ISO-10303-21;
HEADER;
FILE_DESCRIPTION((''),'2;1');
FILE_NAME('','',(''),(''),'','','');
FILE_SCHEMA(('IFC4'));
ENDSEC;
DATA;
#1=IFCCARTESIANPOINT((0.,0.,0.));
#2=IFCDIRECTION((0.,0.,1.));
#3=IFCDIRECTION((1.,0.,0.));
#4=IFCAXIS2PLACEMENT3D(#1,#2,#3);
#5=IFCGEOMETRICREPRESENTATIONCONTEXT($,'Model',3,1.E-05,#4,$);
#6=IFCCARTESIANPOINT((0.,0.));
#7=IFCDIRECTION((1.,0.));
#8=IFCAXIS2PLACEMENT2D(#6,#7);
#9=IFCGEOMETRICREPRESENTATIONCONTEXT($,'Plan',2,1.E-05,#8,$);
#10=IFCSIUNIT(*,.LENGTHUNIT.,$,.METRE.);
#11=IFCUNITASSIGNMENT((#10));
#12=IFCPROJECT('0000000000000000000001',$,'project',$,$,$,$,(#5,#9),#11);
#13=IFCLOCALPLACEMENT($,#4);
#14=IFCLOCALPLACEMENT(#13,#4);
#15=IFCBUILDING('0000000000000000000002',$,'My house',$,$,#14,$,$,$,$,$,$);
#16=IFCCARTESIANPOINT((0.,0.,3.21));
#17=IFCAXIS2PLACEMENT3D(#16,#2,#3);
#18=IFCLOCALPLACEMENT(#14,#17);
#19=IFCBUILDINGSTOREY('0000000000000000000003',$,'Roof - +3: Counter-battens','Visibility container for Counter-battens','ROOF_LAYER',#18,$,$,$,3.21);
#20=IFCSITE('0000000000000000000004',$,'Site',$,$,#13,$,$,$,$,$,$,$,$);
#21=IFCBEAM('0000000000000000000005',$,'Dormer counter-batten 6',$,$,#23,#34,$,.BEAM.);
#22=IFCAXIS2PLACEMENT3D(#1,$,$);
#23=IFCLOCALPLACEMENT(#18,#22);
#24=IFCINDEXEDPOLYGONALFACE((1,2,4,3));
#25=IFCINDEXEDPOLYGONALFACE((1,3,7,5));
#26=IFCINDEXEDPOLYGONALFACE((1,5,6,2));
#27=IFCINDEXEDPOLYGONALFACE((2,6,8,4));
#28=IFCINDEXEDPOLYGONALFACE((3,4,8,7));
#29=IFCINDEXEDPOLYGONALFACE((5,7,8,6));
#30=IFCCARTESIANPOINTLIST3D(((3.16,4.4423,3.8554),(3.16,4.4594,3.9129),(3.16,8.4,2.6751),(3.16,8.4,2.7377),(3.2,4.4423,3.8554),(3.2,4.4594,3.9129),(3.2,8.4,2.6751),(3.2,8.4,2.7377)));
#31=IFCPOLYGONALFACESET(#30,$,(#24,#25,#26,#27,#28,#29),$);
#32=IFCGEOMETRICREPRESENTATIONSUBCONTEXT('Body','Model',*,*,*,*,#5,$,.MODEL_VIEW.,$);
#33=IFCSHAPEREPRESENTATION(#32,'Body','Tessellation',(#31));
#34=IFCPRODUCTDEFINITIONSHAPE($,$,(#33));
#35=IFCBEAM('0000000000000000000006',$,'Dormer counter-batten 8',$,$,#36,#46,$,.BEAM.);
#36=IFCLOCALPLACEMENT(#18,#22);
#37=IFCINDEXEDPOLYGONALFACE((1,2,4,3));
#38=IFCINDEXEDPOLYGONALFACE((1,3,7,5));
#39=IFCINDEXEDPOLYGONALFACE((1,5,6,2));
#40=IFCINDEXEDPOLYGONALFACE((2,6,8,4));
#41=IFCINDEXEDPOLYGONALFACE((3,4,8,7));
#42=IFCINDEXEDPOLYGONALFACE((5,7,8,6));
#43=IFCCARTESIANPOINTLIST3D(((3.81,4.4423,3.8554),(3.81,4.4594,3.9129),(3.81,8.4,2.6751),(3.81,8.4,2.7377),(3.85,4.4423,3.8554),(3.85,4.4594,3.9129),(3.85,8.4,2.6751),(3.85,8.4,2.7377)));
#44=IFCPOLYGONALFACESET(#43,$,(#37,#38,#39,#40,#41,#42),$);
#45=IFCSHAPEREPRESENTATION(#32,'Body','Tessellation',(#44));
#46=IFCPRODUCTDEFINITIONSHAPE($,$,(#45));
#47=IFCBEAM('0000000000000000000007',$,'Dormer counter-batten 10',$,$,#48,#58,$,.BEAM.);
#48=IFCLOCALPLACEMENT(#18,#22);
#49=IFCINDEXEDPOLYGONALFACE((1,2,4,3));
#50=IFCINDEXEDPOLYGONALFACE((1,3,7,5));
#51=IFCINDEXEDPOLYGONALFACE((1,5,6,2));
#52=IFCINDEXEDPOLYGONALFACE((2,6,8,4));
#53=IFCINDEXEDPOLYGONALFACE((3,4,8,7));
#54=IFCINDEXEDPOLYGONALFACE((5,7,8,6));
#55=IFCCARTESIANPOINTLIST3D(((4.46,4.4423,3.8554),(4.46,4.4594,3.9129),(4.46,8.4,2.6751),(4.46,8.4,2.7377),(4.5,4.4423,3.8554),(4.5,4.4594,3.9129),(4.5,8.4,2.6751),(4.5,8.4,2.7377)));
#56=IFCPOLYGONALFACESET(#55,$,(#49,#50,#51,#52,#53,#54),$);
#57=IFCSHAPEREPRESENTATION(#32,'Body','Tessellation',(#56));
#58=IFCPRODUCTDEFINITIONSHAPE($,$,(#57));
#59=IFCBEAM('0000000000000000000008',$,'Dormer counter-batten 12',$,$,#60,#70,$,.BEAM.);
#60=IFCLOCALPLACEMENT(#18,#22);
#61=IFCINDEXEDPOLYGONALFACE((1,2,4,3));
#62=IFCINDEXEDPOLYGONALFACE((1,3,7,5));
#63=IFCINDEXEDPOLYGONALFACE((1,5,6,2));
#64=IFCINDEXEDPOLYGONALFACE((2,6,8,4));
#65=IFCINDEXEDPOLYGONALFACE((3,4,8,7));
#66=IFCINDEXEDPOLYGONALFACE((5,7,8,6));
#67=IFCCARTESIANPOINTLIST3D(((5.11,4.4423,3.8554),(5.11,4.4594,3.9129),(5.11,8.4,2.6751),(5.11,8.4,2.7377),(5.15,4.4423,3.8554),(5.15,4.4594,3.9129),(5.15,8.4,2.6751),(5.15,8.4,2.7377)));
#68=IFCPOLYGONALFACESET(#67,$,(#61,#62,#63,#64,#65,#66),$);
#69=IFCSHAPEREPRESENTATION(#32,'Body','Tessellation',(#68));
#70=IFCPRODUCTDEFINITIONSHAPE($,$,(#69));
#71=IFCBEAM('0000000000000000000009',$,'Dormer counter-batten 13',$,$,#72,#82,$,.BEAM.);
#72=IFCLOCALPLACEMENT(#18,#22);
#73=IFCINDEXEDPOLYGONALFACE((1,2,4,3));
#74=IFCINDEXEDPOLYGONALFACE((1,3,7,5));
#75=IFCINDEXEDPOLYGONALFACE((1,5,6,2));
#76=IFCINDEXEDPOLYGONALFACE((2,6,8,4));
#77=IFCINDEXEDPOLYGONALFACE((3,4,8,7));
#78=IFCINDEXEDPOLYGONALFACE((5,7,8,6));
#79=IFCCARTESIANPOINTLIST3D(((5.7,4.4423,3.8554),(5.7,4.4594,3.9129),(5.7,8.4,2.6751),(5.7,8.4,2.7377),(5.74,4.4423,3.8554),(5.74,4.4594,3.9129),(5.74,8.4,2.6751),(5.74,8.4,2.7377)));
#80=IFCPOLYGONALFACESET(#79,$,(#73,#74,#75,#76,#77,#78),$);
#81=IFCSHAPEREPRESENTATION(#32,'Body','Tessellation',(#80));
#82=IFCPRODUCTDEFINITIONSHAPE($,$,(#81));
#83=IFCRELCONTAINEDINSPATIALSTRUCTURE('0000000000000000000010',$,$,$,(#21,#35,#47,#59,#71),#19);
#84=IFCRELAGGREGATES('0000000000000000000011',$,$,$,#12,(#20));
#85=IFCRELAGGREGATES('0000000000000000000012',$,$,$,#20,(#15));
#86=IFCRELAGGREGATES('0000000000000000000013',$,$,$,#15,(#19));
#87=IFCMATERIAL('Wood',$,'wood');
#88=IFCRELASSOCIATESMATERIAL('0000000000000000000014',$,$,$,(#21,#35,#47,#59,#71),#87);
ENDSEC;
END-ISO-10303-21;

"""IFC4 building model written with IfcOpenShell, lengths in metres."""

from ifc_helpers import new_model, si_unit, frame, origin_with_axes, origin_2d_with_axis, place, context, subcontext, project, spatial, rectangle, extrude, clip, halfspace, material, element, save


model = new_model("IFC4")

# Units and contexts
model_context = context("Model", 3, precision=1e-05, world=origin_with_axes())
plan_context = context("Plan", 2, precision=1e-05, world=origin_2d_with_axis())
body_context = subcontext(model_context, "Body", "Model", "MODEL_VIEW")
ifc_project = project(units=[si_unit("LENGTHUNIT", "METRE")], contexts=[model_context, plan_context])

# Site, building, storey
site_placement = place(None, origin_with_axes())
site = spatial("IfcSite", under=ifc_project, at=site_placement, Name="Site")
building_placement = place(site_placement, origin_with_axes())
building = spatial("IfcBuilding", under=site, at=building_placement, Name="My house")
storey_placement = place(building_placement, frame((0.0, 0.0, 3.21), z_axis=(0.0, 0.0, 1.0), x_axis=(1.0, 0.0, 0.0)))
storey = spatial("IfcBuildingStorey", under=building, at=storey_placement, Name="Roof - +3: Counter-battens", Description="Visibility container for Counter-battens", ObjectType="ROOF_LAYER", Elevation=3.21)

# Beams
ifc_material = material(Name="Wood", Category="wood")
beam_1_placement = place(storey_placement, frame((3.18, 4.4509, 3.8841), z_axis=(0.0, 0.28578, 0.958295), x_axis=(0.0, 0.958295, -0.28578)))
element("IfcBeam", 1, at=beam_1_placement, inside=storey, material=ifc_material, Name="Dormer counter-batten 6", PredefinedType="BEAM", context=body_context, shape_type="Clipping", body=[
    clip(clip(extrude(rectangle(XDim=0.04, YDim=0.06), frame((0.0, 0.0, 0.0), z_axis=(1.0, 0.0, 0.0), x_axis=(0.0, 1.0, 0.0)), (0.0, 0.0, 1.0), 5.5), halfspace(frame((1.5953, 3.18, -6.9271), z_axis=(-0.958295, 0.0, -0.28578), x_axis=(0.0, 1.0, 0.0)), False)), halfspace(frame((5.8118, 3.18, -5.6697), z_axis=(0.958295, 0.0, 0.28578), x_axis=(0.0, -1.0, 0.0)), False)),
])
beam_2_placement = place(storey_placement, frame((3.83, 4.4509, 3.8841), z_axis=(0.0, 0.28578, 0.958295), x_axis=(0.0, 0.958295, -0.28578)))
element("IfcBeam", 2, at=beam_2_placement, inside=storey, material=ifc_material, Name="Dormer counter-batten 8", PredefinedType="BEAM", context=body_context, shape_type="Clipping", body=[
    clip(clip(extrude(rectangle(XDim=0.04, YDim=0.06), frame((0.0, 0.0, 0.0), z_axis=(1.0, 0.0, 0.0), x_axis=(0.0, 1.0, 0.0)), (0.0, 0.0, 1.0), 5.5), halfspace(frame((1.5953, 3.83, -6.9271), z_axis=(-0.958295, 0.0, -0.28578), x_axis=(0.0, 1.0, 0.0)), False)), halfspace(frame((5.8118, 3.83, -5.6697), z_axis=(0.958295, 0.0, 0.28578), x_axis=(0.0, -1.0, 0.0)), False)),
])
beam_3_placement = place(storey_placement, frame((4.48, 4.4509, 3.8841), z_axis=(0.0, 0.28578, 0.958295), x_axis=(0.0, 0.958295, -0.28578)))
element("IfcBeam", 3, at=beam_3_placement, inside=storey, material=ifc_material, Name="Dormer counter-batten 10", PredefinedType="BEAM", context=body_context, shape_type="Clipping", body=[
    clip(clip(extrude(rectangle(XDim=0.04, YDim=0.06), frame((0.0, 0.0, 0.0), z_axis=(1.0, 0.0, 0.0), x_axis=(0.0, 1.0, 0.0)), (0.0, 0.0, 1.0), 5.5), halfspace(frame((1.5953, 4.48, -6.9271), z_axis=(-0.958295, 0.0, -0.28578), x_axis=(0.0, 1.0, 0.0)), False)), halfspace(frame((5.8118, 4.48, -5.6697), z_axis=(0.958295, 0.0, 0.28578), x_axis=(0.0, -1.0, 0.0)), False)),
])
beam_4_placement = place(storey_placement, frame((5.13, 4.4509, 3.8841), z_axis=(0.0, 0.28578, 0.958295), x_axis=(0.0, 0.958295, -0.28578)))
element("IfcBeam", 4, at=beam_4_placement, inside=storey, material=ifc_material, Name="Dormer counter-batten 12", PredefinedType="BEAM", context=body_context, shape_type="Clipping", body=[
    clip(clip(extrude(rectangle(XDim=0.04, YDim=0.06), frame((0.0, 0.0, 0.0), z_axis=(1.0, 0.0, 0.0), x_axis=(0.0, 1.0, 0.0)), (0.0, 0.0, 1.0), 5.5), halfspace(frame((1.5953, 5.13, -6.9271), z_axis=(-0.958295, 0.0, -0.28578), x_axis=(0.0, 1.0, 0.0)), False)), halfspace(frame((5.8118, 5.13, -5.6697), z_axis=(0.958295, 0.0, 0.28578), x_axis=(0.0, -1.0, 0.0)), False)),
])
beam_5_placement = place(storey_placement, frame((5.72, 4.4509, 3.8841), z_axis=(0.0, 0.28578, 0.958295), x_axis=(0.0, 0.958295, -0.28578)))
element("IfcBeam", 5, at=beam_5_placement, inside=storey, material=ifc_material, Name="Dormer counter-batten 13", PredefinedType="BEAM", context=body_context, shape_type="Clipping", body=[
    clip(clip(extrude(rectangle(XDim=0.04, YDim=0.06), frame((0.0, 0.0, 0.0), z_axis=(1.0, 0.0, 0.0), x_axis=(0.0, 1.0, 0.0)), (0.0, 0.0, 1.0), 5.5), halfspace(frame((1.5953, 5.72, -6.9271), z_axis=(-0.958295, 0.0, -0.28578), x_axis=(0.0, 1.0, 0.0)), False)), halfspace(frame((5.8118, 5.72, -5.6697), z_axis=(0.958295, 0.0, 0.28578), x_axis=(0.0, -1.0, 0.0)), False)),
])

save(model, "model.ifc")
